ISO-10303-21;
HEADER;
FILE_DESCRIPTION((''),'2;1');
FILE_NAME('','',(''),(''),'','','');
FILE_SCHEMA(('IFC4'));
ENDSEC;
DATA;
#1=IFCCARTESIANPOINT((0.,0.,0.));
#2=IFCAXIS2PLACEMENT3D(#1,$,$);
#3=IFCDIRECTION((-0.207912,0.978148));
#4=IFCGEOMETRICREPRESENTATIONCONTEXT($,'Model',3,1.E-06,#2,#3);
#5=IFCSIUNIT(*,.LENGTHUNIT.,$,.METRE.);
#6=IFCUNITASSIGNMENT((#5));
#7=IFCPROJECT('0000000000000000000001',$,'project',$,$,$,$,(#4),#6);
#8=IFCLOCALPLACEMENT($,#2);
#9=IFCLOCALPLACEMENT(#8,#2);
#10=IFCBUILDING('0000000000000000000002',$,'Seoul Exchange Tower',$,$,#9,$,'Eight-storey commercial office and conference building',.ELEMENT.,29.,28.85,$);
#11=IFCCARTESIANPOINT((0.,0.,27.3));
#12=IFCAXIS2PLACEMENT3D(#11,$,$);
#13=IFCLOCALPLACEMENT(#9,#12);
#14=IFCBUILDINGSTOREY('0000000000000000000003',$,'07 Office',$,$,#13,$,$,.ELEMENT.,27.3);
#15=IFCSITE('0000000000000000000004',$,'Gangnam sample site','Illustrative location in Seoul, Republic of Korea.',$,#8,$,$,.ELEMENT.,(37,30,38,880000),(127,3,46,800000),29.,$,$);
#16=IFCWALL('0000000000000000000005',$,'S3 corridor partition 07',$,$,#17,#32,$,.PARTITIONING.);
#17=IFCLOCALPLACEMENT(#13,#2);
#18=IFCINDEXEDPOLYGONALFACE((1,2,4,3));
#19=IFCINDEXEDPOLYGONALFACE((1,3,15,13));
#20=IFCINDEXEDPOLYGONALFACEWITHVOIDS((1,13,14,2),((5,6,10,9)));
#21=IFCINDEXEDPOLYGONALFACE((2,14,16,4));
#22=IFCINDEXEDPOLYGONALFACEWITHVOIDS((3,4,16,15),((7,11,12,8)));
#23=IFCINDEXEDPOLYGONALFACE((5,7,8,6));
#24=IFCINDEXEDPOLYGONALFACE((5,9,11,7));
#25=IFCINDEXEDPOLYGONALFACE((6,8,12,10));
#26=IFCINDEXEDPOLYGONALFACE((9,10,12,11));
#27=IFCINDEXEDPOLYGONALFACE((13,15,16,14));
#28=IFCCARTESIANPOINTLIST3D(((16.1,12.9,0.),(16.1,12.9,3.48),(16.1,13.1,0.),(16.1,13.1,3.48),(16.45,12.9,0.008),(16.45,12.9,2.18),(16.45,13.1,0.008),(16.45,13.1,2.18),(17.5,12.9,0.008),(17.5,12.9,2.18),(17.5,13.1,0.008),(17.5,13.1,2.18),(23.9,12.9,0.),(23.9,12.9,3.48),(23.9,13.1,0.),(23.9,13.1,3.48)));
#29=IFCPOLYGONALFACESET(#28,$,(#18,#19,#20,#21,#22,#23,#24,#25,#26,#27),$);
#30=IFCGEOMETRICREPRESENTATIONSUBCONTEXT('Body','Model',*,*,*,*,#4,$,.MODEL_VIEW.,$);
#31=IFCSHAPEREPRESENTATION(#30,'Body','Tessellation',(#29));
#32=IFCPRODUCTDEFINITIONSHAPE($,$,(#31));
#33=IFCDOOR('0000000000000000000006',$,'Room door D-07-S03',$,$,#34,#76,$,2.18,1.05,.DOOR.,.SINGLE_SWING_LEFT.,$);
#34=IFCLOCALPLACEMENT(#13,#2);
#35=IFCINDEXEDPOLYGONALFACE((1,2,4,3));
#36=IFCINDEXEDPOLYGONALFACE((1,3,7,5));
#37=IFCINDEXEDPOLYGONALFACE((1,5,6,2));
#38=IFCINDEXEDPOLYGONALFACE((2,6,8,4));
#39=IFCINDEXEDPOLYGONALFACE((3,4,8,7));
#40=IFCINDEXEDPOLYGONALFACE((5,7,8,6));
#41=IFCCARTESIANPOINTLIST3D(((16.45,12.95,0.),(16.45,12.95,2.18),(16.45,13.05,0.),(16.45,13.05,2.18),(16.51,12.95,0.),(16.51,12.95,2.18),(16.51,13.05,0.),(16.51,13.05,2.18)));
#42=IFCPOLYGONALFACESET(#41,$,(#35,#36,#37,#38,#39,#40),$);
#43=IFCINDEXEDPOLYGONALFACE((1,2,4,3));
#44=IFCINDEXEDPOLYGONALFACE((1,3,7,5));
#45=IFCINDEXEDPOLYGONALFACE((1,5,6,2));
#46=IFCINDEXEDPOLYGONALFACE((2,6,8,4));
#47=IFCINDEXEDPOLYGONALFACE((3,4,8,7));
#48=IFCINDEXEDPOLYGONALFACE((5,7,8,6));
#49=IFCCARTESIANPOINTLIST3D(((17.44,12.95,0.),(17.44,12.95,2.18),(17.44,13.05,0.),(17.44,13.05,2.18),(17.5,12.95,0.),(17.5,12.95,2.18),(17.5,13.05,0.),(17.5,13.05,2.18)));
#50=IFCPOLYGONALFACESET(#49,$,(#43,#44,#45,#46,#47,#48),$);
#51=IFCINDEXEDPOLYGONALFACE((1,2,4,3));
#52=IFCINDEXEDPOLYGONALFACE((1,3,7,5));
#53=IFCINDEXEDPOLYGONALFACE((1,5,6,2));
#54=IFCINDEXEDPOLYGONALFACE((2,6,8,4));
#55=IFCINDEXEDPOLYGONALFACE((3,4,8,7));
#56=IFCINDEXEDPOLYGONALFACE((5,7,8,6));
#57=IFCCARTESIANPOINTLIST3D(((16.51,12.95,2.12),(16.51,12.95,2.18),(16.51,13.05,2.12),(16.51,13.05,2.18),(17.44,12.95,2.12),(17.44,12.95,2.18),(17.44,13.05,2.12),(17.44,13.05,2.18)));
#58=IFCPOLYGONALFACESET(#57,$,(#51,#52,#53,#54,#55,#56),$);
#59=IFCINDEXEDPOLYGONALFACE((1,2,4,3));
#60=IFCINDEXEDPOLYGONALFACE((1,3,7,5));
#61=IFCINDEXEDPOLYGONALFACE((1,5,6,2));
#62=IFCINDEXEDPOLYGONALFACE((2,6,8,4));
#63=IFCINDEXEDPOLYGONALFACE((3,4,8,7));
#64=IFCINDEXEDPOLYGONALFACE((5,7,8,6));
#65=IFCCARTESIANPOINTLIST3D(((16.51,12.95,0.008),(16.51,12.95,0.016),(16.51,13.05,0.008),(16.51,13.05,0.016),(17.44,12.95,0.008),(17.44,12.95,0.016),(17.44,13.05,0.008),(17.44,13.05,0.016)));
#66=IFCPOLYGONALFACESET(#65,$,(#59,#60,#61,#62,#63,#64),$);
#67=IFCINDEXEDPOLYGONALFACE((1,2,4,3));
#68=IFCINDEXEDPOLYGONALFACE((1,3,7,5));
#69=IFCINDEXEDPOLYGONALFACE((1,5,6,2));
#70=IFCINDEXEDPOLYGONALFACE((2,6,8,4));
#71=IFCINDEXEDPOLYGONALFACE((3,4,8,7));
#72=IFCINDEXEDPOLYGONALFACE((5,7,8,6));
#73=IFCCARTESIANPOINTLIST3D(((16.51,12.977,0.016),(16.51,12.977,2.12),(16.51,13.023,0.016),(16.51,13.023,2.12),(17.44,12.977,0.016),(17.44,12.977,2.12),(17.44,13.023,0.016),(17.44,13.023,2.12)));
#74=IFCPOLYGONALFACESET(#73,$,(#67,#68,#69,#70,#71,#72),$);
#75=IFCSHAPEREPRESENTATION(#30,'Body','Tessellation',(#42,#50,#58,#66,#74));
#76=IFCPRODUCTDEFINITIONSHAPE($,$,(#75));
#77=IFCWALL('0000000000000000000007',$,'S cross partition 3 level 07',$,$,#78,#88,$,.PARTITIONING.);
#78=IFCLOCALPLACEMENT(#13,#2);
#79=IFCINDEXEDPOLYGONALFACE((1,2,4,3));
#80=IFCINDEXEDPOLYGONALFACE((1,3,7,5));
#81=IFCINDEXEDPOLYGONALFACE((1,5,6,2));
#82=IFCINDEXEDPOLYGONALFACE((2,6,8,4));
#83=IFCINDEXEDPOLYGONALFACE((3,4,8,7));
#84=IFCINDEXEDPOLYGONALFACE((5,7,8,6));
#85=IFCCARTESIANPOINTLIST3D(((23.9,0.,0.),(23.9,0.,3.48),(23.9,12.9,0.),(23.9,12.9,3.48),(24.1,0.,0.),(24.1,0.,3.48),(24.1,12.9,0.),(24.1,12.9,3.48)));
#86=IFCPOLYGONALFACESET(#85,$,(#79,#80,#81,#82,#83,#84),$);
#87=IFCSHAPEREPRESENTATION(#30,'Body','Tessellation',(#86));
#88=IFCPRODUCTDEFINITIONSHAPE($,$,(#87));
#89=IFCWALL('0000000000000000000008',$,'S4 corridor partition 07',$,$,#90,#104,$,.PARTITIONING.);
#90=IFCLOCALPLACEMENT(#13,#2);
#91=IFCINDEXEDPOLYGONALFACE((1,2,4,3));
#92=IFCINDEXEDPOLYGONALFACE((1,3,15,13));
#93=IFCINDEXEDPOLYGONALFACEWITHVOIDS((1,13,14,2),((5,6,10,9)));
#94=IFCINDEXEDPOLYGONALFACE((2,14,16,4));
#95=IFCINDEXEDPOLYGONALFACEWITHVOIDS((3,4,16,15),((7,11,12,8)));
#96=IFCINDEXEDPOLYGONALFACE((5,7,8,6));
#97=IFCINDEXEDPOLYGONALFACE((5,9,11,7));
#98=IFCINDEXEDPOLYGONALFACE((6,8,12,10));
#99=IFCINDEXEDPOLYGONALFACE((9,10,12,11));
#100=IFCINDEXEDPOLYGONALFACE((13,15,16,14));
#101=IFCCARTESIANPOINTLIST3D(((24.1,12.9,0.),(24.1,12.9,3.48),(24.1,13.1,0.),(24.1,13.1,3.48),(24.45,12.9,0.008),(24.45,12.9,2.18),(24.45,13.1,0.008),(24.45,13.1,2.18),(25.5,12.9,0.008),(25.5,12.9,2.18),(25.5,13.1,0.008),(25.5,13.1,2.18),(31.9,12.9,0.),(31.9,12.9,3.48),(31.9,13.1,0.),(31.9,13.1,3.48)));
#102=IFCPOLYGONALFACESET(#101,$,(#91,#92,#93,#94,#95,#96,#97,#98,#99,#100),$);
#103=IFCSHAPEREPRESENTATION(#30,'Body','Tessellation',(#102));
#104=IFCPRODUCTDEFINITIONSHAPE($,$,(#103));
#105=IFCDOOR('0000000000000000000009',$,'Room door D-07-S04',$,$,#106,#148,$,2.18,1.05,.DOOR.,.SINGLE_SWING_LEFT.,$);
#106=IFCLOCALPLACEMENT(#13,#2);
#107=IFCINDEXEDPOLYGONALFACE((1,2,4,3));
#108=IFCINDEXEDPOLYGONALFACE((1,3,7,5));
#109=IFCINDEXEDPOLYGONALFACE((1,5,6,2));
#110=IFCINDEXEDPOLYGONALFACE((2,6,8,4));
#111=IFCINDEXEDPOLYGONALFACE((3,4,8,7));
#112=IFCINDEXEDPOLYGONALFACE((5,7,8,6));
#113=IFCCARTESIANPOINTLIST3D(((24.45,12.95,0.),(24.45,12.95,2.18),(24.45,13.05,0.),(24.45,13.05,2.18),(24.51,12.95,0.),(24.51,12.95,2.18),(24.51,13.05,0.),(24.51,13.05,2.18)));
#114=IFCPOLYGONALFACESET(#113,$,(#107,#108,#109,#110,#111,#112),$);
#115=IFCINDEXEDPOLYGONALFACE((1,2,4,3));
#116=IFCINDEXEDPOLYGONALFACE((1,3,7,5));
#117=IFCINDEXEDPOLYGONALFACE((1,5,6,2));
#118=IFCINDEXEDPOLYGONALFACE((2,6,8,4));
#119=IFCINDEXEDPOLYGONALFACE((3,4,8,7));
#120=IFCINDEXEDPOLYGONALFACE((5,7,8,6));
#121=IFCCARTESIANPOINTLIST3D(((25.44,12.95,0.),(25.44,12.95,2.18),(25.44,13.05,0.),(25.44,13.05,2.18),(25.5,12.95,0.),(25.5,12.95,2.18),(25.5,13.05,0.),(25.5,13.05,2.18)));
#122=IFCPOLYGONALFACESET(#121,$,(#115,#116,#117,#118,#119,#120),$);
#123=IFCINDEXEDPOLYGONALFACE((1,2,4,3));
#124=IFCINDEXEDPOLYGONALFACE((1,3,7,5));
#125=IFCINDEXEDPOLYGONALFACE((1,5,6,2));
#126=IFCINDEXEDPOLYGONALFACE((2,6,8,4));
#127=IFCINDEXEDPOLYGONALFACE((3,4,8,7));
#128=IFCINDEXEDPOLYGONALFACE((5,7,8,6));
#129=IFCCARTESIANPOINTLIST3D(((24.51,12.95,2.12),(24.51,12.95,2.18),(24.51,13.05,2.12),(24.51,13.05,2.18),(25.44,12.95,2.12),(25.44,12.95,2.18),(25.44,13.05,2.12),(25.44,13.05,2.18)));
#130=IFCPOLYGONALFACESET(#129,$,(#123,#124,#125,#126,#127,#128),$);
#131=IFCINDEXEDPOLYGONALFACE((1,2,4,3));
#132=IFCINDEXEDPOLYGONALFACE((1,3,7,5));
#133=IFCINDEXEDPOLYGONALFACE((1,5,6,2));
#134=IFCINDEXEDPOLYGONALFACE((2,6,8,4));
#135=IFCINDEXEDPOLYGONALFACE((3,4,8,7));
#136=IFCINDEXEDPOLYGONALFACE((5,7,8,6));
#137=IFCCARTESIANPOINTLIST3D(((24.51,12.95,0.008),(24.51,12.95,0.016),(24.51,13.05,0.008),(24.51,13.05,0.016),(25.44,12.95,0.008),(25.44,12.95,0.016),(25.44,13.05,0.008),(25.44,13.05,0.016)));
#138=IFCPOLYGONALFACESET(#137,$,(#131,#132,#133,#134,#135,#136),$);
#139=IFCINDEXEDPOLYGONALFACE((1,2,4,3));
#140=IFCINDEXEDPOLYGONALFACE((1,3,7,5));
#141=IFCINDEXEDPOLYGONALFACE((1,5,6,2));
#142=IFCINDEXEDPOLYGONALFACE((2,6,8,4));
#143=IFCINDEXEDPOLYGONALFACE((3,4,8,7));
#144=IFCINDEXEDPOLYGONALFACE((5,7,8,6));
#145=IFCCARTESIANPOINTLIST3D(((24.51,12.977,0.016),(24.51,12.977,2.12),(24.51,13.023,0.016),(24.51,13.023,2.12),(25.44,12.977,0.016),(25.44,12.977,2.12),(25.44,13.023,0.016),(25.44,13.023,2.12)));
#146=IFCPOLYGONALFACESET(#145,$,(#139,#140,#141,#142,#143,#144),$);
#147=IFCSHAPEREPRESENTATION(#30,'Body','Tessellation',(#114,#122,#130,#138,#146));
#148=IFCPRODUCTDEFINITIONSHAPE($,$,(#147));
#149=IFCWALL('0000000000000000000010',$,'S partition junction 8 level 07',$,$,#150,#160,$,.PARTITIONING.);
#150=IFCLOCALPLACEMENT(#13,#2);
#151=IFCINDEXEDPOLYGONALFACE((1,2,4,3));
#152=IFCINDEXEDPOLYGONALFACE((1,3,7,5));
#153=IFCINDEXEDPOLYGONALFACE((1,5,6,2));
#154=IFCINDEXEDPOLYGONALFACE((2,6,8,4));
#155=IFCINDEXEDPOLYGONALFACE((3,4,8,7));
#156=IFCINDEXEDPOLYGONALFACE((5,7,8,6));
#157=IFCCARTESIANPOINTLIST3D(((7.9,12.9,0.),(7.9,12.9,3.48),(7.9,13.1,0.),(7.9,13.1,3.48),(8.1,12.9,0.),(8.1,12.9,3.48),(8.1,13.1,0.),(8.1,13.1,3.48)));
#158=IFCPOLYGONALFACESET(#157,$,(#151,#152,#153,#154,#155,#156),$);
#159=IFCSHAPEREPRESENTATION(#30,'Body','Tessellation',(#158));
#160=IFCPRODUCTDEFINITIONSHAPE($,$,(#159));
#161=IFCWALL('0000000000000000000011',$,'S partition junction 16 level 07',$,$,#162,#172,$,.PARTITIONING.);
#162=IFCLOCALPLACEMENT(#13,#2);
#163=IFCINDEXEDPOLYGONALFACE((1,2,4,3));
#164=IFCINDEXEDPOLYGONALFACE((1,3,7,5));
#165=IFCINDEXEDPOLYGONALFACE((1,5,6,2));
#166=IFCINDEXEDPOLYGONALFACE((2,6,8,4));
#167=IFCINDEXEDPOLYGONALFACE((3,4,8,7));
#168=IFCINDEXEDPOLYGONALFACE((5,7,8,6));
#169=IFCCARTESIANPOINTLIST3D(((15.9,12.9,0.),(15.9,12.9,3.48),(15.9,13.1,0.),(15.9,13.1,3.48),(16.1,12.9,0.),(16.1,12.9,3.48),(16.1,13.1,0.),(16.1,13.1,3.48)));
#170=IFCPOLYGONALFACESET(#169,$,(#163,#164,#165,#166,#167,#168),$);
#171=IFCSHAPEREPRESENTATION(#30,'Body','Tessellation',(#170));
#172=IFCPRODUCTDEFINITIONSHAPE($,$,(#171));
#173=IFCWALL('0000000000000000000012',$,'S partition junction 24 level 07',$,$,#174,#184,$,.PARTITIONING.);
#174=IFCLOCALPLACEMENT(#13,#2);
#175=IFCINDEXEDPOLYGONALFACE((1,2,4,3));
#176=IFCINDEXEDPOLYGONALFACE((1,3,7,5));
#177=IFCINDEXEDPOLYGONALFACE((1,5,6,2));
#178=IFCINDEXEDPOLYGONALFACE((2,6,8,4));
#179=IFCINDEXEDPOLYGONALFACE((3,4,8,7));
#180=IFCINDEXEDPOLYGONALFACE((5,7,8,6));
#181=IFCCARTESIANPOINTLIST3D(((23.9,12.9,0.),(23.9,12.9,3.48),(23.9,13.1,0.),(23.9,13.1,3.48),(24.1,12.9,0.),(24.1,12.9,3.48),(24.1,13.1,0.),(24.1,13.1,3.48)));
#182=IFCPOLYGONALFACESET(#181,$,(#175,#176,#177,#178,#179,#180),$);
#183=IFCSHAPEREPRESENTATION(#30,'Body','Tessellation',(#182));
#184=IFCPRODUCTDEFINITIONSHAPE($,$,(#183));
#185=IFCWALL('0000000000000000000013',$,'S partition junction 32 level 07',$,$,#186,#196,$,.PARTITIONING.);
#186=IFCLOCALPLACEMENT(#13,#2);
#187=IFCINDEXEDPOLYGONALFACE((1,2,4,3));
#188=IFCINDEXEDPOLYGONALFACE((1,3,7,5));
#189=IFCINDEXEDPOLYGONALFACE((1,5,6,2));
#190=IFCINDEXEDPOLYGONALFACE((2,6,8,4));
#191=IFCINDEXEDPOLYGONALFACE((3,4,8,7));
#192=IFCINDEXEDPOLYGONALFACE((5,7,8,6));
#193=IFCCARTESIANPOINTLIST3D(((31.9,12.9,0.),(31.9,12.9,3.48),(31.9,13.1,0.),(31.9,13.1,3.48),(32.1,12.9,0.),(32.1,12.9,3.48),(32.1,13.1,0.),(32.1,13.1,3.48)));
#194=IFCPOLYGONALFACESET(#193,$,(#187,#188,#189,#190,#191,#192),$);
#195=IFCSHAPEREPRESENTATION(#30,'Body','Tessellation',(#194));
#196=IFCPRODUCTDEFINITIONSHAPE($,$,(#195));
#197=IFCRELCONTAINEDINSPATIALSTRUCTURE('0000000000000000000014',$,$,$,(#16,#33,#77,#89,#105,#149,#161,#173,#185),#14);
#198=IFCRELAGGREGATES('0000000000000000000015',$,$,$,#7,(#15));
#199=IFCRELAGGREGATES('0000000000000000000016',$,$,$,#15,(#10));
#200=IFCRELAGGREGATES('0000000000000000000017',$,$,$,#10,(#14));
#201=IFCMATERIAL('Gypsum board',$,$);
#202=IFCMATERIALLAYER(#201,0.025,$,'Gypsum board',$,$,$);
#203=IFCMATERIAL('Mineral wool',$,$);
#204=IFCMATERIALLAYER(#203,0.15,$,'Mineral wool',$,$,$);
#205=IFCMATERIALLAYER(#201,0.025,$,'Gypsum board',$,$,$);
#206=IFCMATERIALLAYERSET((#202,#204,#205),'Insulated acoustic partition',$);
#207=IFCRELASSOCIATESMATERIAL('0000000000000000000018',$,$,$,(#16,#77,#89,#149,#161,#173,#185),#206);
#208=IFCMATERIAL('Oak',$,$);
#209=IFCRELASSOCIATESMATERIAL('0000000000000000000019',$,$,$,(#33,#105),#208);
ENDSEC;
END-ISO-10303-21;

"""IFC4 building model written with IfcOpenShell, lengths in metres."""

from ifc_helpers import new_model, si_unit, direction, frame, frame_2d, origin, place, context, subcontext, project, spatial, rectangle, extrude, material, layer, layer_set, layer_usage, element, fill, save


model = new_model("IFC4")

# Units and contexts
model_context = context("Model", 3, precision=1e-06, world=origin(), true_north=direction((-0.207912, 0.978148)))
body_context = subcontext(model_context, "Body", "Model", "MODEL_VIEW")
ifc_project = project(units=[si_unit("LENGTHUNIT", "METRE")], contexts=[model_context])

# Site, building, storey
site_placement = place(None, origin())
site = spatial("IfcSite", under=ifc_project, at=site_placement, Name="Gangnam sample site", Description="Illustrative location in Seoul, Republic of Korea.", CompositionType="ELEMENT", RefLatitude=(37, 30, 38, 880000), RefLongitude=(127, 3, 46, 800000), RefElevation=29.0)
building_placement = place(site_placement, origin())
building = spatial("IfcBuilding", under=site, at=building_placement, Name="Seoul Exchange Tower", LongName="Eight-storey commercial office and conference building", CompositionType="ELEMENT", ElevationOfRefHeight=29.0, ElevationOfTerrain=28.85)
storey_placement = place(building_placement, frame((0.0, 0.0, 27.3)))
storey = spatial("IfcBuildingStorey", under=building, at=storey_placement, Name="07 Office", CompositionType="ELEMENT", Elevation=27.3)

# Shared definitions
ifc_material_1 = material(Name="Gypsum board")
ifc_layer_1 = layer(ifc_material_1, 0.025, Name="Gypsum board")
ifc_material_2 = material(Name="Mineral wool")
ifc_layer_2 = layer(ifc_material_2, 0.15, Name="Mineral wool")
ifc_layer_3 = layer(ifc_material_1, 0.025, Name="Gypsum board")
ifc_layer_set = layer_set([ifc_layer_1, ifc_layer_2, ifc_layer_3], Name="Insulated acoustic partition")
ifc_layer_usage = layer_usage(ifc_layer_set, "AXIS2", "POSITIVE", 0.0)

# Shared definitions
ifc_material_3 = material(Name="Oak")

# Wall, opening, door
wall_1_placement = place(storey_placement, frame((16.1, 12.9, 0.0)))
wall_1 = element("IfcWall", 1, at=wall_1_placement, inside=storey, material=ifc_layer_usage, Name="S3 corridor partition 07", PredefinedType="PARTITIONING", context=body_context, shape_type="SweptSolid", body=[
    extrude(rectangle(XDim=7.8, YDim=0.2, at=frame_2d((3.9, 0.1))), origin(), (0.0, 0.0, 1.0), 3.48),
])
placement_1 = place(wall_1_placement, origin())
opening_1 = element("IfcOpeningElement", 2, at=placement_1, cuts=wall_1, PredefinedType="OPENING", context=body_context, shape_type="SweptSolid", body=[
    extrude(rectangle(XDim=1.05, YDim=0.24, at=frame_2d((0.525, 0.12))), frame((0.35, -0.02, 0.008)), (0.0, 0.0, 1.0), 2.172),
])
door_1 = element("IfcDoor", 3, at=placement_1, inside=storey, material=ifc_material_3, Name="Room door D-07-S03", OperationType="SINGLE_SWING_LEFT", OverallHeight=2.18, OverallWidth=1.05, PredefinedType="DOOR", context=body_context, shape_type="SweptSolid", body=[
    extrude(rectangle(XDim=0.06, YDim=0.1, at=frame_2d((0.03, 0.05))), frame((0.35, 0.05, 0.0)), (0.0, 0.0, 1.0), 2.18),
    extrude(rectangle(XDim=0.06, YDim=0.1, at=frame_2d((0.03, 0.05))), frame((1.34, 0.05, 0.0)), (0.0, 0.0, 1.0), 2.18),
    extrude(rectangle(XDim=0.93, YDim=0.1, at=frame_2d((0.465, 0.05))), frame((0.41, 0.05, 2.12)), (0.0, 0.0, 1.0), 0.06),
    extrude(rectangle(XDim=0.93, YDim=0.1, at=frame_2d((0.465, 0.05))), frame((0.41, 0.05, 0.008)), (0.0, 0.0, 1.0), 0.008),
    extrude(rectangle(XDim=0.93, YDim=0.046, at=frame_2d((0.465, 0.023))), frame((0.41, 0.077, 0.016)), (0.0, 0.0, 1.0), 2.104),
])
fill(opening_1, door_1)

# Wall
wall_2_placement = place(storey_placement, frame((24.1, 0.0, 0.0), z_axis=(0.0, 0.0, 1.0), x_axis=(0.0, 1.0, 0.0)))
element("IfcWall", 4, at=wall_2_placement, inside=storey, material=ifc_layer_usage, Name="S cross partition 3 level 07", PredefinedType="PARTITIONING", context=body_context, shape_type="SweptSolid", body=[
    extrude(rectangle(XDim=12.9, YDim=0.2, at=frame_2d((6.45, 0.1))), origin(), (0.0, 0.0, 1.0), 3.48),
])

# Wall, opening, door
wall_3_placement = place(storey_placement, frame((24.1, 12.9, 0.0)))
wall_3 = element("IfcWall", 5, at=wall_3_placement, inside=storey, material=ifc_layer_usage, Name="S4 corridor partition 07", PredefinedType="PARTITIONING", context=body_context, shape_type="SweptSolid", body=[
    extrude(rectangle(XDim=7.8, YDim=0.2, at=frame_2d((3.9, 0.1))), origin(), (0.0, 0.0, 1.0), 3.48),
])
placement_2 = place(wall_3_placement, origin())
opening_2 = element("IfcOpeningElement", 6, at=placement_2, cuts=wall_3, PredefinedType="OPENING", context=body_context, shape_type="SweptSolid", body=[
    extrude(rectangle(XDim=1.05, YDim=0.24, at=frame_2d((0.525, 0.12))), frame((0.35, -0.02, 0.008)), (0.0, 0.0, 1.0), 2.172),
])
door_2 = element("IfcDoor", 7, at=placement_2, inside=storey, material=ifc_material_3, Name="Room door D-07-S04", OperationType="SINGLE_SWING_LEFT", OverallHeight=2.18, OverallWidth=1.05, PredefinedType="DOOR", context=body_context, shape_type="SweptSolid", body=[
    extrude(rectangle(XDim=0.06, YDim=0.1, at=frame_2d((0.03, 0.05))), frame((0.35, 0.05, 0.0)), (0.0, 0.0, 1.0), 2.18),
    extrude(rectangle(XDim=0.06, YDim=0.1, at=frame_2d((0.03, 0.05))), frame((1.34, 0.05, 0.0)), (0.0, 0.0, 1.0), 2.18),
    extrude(rectangle(XDim=0.93, YDim=0.1, at=frame_2d((0.465, 0.05))), frame((0.41, 0.05, 2.12)), (0.0, 0.0, 1.0), 0.06),
    extrude(rectangle(XDim=0.93, YDim=0.1, at=frame_2d((0.465, 0.05))), frame((0.41, 0.05, 0.008)), (0.0, 0.0, 1.0), 0.008),
    extrude(rectangle(XDim=0.93, YDim=0.046, at=frame_2d((0.465, 0.023))), frame((0.41, 0.077, 0.016)), (0.0, 0.0, 1.0), 2.104),
])
fill(opening_2, door_2)

# Walls
for number, where, name in (
    (8, (7.9, 12.9, 0.0), "S partition junction 8 level 07"),
    (9, (15.9, 12.9, 0.0), "S partition junction 16 level 07"),
    (10, (23.9, 12.9, 0.0), "S partition junction 24 level 07"),
    (11, (31.9, 12.9, 0.0), "S partition junction 32 level 07"),
):
    element("IfcWall", number, at=place(storey_placement, frame(where)), inside=storey, material=ifc_layer_usage, Name=name, PredefinedType="PARTITIONING", context=body_context, shape_type="SweptSolid", body=[
        extrude(rectangle(XDim=0.2, YDim=0.2, at=frame_2d((0.1, 0.1))), origin(), (0.0, 0.0, 1.0), 3.48),
    ])

save(model, "model.ifc")
